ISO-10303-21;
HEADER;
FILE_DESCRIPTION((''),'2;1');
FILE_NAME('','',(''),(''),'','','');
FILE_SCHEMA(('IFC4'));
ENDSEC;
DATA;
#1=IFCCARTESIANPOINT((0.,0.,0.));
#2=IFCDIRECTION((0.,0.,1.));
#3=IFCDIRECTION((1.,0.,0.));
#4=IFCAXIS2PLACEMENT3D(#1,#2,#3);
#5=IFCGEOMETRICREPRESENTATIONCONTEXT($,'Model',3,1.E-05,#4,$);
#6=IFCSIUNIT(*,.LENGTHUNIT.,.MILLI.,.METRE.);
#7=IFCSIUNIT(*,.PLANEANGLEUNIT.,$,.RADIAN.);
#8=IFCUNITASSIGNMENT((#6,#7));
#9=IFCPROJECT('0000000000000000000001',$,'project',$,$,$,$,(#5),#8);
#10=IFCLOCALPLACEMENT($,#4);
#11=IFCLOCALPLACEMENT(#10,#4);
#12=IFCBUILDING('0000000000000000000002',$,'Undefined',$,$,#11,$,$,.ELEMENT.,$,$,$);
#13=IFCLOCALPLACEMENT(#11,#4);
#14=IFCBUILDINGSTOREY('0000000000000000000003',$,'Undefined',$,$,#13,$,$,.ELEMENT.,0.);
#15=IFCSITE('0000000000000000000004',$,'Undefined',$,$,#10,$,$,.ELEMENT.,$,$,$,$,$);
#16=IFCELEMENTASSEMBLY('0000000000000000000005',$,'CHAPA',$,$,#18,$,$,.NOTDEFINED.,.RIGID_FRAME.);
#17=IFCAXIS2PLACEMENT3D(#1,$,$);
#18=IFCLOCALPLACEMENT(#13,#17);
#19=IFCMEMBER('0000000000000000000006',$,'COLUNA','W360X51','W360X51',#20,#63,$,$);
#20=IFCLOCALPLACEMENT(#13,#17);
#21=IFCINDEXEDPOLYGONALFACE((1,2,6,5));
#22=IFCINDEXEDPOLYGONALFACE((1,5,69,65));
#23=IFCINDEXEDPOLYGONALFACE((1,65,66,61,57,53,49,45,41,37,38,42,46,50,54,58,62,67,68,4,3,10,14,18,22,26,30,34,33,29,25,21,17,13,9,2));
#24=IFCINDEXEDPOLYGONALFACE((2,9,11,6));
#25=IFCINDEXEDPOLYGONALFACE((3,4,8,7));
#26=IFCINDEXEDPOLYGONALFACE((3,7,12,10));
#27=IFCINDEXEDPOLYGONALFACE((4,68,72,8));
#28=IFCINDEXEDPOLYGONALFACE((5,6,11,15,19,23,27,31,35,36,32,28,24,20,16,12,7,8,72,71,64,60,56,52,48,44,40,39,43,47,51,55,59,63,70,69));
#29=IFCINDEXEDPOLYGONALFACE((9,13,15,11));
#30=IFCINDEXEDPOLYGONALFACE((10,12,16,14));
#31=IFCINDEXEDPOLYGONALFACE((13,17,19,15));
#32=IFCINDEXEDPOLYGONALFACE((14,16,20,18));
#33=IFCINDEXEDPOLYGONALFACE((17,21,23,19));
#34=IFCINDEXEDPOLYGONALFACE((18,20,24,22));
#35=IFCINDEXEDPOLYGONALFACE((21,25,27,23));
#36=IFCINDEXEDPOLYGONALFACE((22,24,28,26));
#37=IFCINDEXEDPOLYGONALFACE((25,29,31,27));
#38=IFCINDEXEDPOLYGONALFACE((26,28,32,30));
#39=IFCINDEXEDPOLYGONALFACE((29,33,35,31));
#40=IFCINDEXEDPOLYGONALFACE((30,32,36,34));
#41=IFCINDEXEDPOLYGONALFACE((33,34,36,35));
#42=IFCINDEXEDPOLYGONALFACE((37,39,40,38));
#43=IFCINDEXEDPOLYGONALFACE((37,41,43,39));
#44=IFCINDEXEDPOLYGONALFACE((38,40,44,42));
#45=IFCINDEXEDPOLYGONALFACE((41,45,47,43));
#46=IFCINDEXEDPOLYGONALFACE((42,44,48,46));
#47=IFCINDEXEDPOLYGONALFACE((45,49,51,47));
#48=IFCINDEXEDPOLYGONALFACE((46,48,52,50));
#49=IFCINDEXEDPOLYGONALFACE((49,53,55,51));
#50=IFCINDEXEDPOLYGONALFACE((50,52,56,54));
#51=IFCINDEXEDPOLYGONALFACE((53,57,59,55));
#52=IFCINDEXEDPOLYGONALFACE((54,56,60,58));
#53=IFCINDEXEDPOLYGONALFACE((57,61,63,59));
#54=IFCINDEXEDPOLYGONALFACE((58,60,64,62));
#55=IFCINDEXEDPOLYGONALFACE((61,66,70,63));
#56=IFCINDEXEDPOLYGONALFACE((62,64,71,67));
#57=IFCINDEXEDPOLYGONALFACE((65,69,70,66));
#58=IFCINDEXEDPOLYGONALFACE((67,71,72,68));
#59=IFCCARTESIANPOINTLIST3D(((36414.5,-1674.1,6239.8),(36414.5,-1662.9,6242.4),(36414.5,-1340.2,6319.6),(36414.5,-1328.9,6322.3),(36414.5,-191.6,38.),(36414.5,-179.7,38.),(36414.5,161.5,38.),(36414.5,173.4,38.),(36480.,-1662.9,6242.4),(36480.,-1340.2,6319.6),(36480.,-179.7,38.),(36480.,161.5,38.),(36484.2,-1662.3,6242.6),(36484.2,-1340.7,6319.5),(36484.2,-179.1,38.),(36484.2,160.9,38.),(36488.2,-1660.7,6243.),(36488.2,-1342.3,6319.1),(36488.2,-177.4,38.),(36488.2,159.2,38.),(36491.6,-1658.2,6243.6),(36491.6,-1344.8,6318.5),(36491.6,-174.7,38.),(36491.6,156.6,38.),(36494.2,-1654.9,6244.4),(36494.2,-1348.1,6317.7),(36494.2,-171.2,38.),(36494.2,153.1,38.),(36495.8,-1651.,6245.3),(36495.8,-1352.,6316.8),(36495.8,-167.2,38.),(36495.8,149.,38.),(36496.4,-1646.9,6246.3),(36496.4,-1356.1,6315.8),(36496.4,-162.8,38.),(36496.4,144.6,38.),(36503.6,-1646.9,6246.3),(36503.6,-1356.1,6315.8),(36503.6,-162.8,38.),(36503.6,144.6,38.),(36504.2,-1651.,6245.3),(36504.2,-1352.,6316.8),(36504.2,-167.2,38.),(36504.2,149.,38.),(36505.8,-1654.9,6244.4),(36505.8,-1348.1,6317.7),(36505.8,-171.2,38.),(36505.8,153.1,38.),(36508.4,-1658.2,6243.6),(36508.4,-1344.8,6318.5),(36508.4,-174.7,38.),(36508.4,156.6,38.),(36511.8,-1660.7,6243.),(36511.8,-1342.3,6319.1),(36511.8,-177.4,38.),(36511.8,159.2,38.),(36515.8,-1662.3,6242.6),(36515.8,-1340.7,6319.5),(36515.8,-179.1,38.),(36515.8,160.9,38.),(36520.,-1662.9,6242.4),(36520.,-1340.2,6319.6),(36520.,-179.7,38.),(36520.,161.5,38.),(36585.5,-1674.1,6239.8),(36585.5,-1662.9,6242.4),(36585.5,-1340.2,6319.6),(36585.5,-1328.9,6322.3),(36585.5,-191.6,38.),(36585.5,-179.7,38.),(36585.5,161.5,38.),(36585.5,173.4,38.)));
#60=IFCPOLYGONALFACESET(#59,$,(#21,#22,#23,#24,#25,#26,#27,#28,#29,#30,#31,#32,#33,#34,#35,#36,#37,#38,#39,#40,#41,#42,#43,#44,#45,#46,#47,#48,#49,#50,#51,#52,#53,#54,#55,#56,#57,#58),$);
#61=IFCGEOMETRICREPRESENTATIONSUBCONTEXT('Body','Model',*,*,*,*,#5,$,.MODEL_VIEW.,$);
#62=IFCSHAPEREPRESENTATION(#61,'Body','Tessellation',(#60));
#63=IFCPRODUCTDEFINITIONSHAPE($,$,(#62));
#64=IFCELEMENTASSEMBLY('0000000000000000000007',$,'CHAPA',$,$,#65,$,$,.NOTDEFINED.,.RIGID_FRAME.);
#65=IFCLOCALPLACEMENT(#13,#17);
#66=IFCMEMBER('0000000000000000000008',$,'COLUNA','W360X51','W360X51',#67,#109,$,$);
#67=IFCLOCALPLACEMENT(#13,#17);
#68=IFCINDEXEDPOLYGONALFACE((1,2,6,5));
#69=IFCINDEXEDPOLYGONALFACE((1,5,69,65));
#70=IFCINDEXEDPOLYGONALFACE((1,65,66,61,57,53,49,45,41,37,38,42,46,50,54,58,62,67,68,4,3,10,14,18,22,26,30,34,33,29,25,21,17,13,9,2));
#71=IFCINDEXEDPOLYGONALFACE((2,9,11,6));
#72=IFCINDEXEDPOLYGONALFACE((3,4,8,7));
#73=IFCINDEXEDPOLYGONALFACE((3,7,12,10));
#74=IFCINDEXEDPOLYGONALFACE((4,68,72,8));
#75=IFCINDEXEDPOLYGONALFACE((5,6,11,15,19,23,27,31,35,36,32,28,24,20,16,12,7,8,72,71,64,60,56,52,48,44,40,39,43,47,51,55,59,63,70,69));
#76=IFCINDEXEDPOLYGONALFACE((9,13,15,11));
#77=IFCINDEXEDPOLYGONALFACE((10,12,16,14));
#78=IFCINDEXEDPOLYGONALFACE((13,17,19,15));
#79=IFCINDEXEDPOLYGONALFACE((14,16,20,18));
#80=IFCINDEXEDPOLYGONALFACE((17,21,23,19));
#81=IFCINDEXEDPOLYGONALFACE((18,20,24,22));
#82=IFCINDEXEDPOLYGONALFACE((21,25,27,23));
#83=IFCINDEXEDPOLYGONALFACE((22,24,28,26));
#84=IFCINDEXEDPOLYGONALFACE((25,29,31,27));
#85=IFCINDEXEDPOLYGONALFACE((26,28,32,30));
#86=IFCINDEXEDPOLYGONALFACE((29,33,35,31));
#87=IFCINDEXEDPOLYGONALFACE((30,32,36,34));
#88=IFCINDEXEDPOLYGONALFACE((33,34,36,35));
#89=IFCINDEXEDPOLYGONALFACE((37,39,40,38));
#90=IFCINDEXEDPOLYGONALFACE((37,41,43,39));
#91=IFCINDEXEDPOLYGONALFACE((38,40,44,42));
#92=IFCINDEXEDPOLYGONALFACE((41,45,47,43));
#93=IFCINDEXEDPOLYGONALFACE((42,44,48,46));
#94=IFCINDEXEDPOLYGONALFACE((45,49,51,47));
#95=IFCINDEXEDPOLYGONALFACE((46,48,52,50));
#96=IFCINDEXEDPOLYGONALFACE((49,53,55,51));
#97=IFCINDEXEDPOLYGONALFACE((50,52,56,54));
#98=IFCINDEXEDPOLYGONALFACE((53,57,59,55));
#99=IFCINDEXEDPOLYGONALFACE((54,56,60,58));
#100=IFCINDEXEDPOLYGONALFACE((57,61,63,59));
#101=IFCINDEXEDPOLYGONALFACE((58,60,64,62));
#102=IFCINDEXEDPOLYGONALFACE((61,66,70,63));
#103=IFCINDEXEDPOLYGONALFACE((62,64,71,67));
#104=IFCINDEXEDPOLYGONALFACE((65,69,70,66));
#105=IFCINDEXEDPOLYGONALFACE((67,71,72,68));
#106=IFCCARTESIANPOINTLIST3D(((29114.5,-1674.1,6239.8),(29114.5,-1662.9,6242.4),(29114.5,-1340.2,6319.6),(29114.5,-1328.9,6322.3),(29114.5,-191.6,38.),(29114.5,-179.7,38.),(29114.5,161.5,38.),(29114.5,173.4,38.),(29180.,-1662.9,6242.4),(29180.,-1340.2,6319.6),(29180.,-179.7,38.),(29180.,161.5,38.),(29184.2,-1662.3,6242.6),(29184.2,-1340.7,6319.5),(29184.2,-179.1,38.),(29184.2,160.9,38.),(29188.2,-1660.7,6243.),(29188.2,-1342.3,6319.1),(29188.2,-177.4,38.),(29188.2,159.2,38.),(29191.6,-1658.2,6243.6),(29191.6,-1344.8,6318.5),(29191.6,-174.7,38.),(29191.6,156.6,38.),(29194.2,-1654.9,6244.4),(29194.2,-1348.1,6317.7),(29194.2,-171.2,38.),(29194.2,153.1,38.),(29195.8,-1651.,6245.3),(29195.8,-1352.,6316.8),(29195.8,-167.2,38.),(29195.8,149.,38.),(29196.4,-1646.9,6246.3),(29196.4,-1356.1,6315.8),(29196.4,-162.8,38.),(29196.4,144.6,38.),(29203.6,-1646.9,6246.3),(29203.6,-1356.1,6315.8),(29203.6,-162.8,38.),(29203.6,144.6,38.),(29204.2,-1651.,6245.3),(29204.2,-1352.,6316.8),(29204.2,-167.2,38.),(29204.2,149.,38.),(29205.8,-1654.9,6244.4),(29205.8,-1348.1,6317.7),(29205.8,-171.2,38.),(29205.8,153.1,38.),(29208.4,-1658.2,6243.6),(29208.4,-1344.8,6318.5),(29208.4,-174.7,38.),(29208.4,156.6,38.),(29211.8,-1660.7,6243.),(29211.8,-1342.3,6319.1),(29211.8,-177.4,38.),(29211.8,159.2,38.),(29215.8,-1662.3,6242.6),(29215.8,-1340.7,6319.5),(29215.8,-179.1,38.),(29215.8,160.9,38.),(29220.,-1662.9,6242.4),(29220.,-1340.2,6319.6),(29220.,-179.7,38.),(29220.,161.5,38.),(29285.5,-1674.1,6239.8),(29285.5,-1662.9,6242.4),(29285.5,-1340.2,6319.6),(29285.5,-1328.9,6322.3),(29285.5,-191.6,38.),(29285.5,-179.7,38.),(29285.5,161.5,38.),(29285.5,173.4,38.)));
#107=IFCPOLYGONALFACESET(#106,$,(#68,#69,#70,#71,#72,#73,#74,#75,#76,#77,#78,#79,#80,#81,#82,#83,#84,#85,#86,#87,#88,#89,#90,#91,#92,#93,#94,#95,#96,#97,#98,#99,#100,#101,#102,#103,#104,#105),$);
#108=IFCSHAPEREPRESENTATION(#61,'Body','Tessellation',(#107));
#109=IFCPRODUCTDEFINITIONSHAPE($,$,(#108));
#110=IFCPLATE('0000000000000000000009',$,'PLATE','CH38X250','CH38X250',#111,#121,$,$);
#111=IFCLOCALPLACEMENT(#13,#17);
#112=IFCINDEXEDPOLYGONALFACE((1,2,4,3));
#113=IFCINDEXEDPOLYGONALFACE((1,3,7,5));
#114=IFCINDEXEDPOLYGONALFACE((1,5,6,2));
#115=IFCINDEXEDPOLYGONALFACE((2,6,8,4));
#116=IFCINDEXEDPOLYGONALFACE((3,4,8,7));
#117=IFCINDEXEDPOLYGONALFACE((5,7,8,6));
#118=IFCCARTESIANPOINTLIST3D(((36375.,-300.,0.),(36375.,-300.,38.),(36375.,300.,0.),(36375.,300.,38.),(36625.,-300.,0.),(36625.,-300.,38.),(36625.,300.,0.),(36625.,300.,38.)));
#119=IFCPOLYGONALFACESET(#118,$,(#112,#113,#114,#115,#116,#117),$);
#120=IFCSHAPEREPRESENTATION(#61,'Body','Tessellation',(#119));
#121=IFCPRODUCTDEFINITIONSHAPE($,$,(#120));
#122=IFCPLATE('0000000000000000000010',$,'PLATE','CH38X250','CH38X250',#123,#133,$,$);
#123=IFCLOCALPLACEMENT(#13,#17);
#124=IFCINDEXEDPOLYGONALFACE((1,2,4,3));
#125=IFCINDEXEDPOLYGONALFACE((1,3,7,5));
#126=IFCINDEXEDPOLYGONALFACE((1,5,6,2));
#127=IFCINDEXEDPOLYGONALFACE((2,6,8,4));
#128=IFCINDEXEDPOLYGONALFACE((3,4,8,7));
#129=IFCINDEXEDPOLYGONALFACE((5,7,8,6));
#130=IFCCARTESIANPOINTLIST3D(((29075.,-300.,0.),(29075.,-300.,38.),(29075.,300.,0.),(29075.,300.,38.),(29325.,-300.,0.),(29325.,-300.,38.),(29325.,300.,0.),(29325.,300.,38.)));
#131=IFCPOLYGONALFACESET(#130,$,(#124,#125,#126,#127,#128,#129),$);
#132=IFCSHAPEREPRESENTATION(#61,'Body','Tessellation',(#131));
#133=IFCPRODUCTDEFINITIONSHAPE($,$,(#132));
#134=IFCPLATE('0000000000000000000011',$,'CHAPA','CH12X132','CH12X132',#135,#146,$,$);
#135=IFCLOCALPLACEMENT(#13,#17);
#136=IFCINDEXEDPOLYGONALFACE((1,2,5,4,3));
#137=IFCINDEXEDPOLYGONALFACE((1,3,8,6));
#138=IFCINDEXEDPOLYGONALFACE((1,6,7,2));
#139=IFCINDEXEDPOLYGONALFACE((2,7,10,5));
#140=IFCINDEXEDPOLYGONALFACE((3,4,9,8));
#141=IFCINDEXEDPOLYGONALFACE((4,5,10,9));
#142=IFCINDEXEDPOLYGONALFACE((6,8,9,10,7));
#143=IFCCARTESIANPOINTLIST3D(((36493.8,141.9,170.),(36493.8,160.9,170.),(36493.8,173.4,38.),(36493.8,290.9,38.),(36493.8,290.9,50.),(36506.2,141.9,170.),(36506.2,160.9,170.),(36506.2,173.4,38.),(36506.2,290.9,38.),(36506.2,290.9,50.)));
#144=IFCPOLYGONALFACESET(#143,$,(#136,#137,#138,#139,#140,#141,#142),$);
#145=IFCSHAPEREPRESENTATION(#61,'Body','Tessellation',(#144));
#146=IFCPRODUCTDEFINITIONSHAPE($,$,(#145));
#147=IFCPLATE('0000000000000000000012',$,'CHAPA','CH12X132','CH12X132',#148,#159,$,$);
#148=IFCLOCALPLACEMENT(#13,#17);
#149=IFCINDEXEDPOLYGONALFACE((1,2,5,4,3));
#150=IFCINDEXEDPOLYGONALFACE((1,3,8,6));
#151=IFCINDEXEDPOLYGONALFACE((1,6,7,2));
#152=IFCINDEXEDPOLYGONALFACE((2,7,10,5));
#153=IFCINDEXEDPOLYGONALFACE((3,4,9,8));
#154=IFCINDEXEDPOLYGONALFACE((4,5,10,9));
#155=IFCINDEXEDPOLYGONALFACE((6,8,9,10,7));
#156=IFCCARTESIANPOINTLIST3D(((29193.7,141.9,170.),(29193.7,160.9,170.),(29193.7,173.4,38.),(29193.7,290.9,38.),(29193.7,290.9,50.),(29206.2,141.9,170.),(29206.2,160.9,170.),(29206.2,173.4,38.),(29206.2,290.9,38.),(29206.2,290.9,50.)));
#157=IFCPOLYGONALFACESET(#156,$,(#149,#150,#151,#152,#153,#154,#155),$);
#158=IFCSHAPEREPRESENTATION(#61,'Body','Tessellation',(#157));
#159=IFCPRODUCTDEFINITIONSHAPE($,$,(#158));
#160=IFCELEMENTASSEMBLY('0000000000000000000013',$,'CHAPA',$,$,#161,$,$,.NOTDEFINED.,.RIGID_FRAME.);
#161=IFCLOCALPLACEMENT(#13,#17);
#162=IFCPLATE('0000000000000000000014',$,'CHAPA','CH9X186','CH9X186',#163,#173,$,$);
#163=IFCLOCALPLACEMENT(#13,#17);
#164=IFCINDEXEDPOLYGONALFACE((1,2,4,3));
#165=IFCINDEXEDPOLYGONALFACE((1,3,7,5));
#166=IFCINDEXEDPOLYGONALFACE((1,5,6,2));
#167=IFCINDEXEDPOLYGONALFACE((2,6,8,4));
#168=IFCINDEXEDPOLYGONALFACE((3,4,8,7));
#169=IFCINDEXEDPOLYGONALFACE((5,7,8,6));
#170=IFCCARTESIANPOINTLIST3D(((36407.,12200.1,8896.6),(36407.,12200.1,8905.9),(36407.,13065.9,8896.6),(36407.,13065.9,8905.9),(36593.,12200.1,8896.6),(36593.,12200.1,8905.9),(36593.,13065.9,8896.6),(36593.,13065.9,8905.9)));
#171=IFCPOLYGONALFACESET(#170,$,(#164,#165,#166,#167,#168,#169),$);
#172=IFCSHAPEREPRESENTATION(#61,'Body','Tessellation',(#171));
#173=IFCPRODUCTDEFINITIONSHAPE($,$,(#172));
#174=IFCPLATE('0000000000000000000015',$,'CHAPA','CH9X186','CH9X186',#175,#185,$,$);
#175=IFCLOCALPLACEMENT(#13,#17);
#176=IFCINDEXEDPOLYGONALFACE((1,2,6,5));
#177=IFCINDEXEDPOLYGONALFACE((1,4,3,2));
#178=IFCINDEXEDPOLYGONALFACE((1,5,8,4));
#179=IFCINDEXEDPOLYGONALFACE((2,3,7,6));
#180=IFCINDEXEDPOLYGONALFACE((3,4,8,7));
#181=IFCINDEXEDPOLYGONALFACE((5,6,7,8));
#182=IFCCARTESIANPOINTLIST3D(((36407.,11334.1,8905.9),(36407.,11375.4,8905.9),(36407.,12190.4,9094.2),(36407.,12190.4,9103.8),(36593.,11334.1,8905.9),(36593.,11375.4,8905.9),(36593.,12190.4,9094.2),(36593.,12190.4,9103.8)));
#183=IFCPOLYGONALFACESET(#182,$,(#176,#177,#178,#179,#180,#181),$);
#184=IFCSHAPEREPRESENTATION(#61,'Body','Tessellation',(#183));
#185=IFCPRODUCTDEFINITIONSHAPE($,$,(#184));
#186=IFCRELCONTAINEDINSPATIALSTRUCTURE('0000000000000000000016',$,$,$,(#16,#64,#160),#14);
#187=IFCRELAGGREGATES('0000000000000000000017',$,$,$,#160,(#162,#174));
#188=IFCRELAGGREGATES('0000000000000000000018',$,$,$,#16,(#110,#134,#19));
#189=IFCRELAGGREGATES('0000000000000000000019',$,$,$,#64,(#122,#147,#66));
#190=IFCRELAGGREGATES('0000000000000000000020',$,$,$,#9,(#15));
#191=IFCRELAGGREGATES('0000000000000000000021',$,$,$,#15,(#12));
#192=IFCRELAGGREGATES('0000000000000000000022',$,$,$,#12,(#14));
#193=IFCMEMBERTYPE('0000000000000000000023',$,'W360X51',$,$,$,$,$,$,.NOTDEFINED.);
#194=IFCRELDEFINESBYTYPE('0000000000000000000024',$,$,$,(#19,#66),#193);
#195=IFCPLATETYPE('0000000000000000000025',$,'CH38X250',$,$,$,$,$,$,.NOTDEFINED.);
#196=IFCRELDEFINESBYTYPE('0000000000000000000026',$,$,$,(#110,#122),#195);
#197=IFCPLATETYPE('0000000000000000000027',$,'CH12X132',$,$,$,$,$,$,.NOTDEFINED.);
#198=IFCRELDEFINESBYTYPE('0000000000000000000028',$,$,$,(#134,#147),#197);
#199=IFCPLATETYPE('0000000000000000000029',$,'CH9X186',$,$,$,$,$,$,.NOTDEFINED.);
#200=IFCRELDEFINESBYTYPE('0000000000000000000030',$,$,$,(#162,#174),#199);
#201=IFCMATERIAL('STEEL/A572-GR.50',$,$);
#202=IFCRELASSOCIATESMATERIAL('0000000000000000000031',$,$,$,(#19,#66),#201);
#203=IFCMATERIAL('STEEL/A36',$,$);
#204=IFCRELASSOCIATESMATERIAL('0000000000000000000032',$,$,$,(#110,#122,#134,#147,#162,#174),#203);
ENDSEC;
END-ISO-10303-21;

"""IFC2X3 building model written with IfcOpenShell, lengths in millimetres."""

from ifc_helpers import new_model, si_unit, frame, origin_with_axes, origin_2d_with_axis, place, context, subcontext, project, spatial, polyline, i_section, outline, extrude, clip, halfspace, material, type_object, element, aggregate, save


model = new_model("IFC2X3")

# Units and contexts
model_context = context("Model", 3, precision=1e-05, world=origin_with_axes())
body_context = subcontext(model_context, "Body", "Model", "MODEL_VIEW")
ifc_project = project(units=[si_unit("LENGTHUNIT", "METRE", prefix="MILLI"), si_unit("PLANEANGLEUNIT", "RADIAN")], contexts=[model_context])

# Site, building, storey
site_placement = place(None, origin_with_axes())
site = spatial("IfcSite", under=ifc_project, at=site_placement, Name="Undefined", CompositionType="ELEMENT")
building_placement = place(site_placement, origin_with_axes())
building = spatial("IfcBuilding", under=site, at=building_placement, Name="Undefined", CompositionType="ELEMENT")
storey_placement = place(building_placement, origin_with_axes())
storey = spatial("IfcBuildingStorey", under=building, at=storey_placement, Name="Undefined", CompositionType="ELEMENT", Elevation=0.0)

# Element assemblies, members
assembly_1_placement = place(storey_placement, origin_with_axes())
assembly_1 = element("IfcElementAssembly", 1, at=assembly_1_placement, inside=storey, Name="CHAPA", AssemblyPlace="NOTDEFINED", PredefinedType="RIGID_FRAME")
ifc_material_1 = material(Name="STEEL/A572-GR.50")
member_type = type_object("IfcMemberType", Name="W360X51", PredefinedType="NOTDEFINED")
member_1_placement = place(assembly_1_placement, frame((36500.0, 23.3, -97.3), z_axis=(0.0, -0.972595, -0.232504), x_axis=(0.0, -0.232504, 0.972595)))
member_1 = element("IfcMember", 2, at=member_1_placement, type_object=member_type, material=ifc_material_1, Name="COLUNA", Description="W360X51", ObjectType="W360X51", context=body_context, shape_type="Clipping", body=[
    clip(clip(extrude(i_section(OverallWidth=171.0, OverallDepth=355.0, WebThickness=7.2, FlangeThickness=11.6, FilletRadius=16.4, at=origin_2d_with_axis()), frame((6558.0, 0.0, 0.0), z_axis=(-1.0, 0.0, 0.0), x_axis=(0.0, -1.0, 0.0)), (0.0, 0.0, 1.0), 6542.9), halfspace(frame((94.5, 85.5, -186.3), z_axis=(-0.972595, 0.0, 0.232504), x_axis=(0.232504, 0.0, 0.972595)), False)), halfspace(frame((96.6, 0.0, -177.5), z_axis=(0.972595, 0.0, -0.232504), x_axis=(0.0, -1.0, 0.0)), True)),
])
assembly_2_placement = place(storey_placement, origin_with_axes())
assembly_2 = element("IfcElementAssembly", 3, at=assembly_2_placement, inside=storey, Name="CHAPA", AssemblyPlace="NOTDEFINED", PredefinedType="RIGID_FRAME")
member_2_placement = place(assembly_2_placement, frame((29200.0, 23.3, -97.3), z_axis=(0.0, -0.972595, -0.232504), x_axis=(0.0, -0.232504, 0.972595)))
member_2 = element("IfcMember", 4, at=member_2_placement, type_object=member_type, material=ifc_material_1, Name="COLUNA", Description="W360X51", ObjectType="W360X51", context=body_context, shape_type="Clipping", body=[
    clip(clip(extrude(i_section(OverallWidth=171.0, OverallDepth=355.0, WebThickness=7.2, FlangeThickness=11.6, FilletRadius=16.4, at=origin_2d_with_axis()), frame((6558.0, 0.0, 0.0), z_axis=(-1.0, 0.0, 0.0), x_axis=(0.0, -1.0, 0.0)), (0.0, 0.0, 1.0), 6542.9), halfspace(frame((94.5, 85.5, -186.3), z_axis=(-0.972595, 0.0, 0.232504), x_axis=(0.232504, 0.0, 0.972595)), False)), halfspace(frame((96.6, 0.0, -177.5), z_axis=(0.972595, 0.0, -0.232504), x_axis=(0.0, -1.0, 0.0)), True)),
])

# Plates
ifc_material_2 = material(Name="STEEL/A36")
plate_type_1 = type_object("IfcPlateType", Name="CH38X250", PredefinedType="NOTDEFINED")
plate_1_placement = place(assembly_1_placement, frame((36625.0, -300.0, 19.0), z_axis=(0.0, 0.0, 1.0), x_axis=(0.0, 1.0, 0.0)))
plate_1 = element("IfcPlate", 5, at=plate_1_placement, type_object=plate_type_1, material=ifc_material_2, Name="PLATE", Description="CH38X250", ObjectType="CH38X250", context=body_context, shape_type="SweptSolid", body=[
    extrude(outline(polyline([(0.0, 0.0), (600.0, 0.0), (600.0, 250.0), (0.0, 250.0), (0.0, 0.0)])), frame((0.0, 0.0, -19.0), z_axis=(0.0, 0.0, 1.0), x_axis=(1.0, 0.0, 0.0)), (0.0, 0.0, 1.0), 38.0),
])
plate_2_placement = place(assembly_2_placement, frame((29325.0, -300.0, 19.0), z_axis=(0.0, 0.0, 1.0), x_axis=(0.0, 1.0, 0.0)))
plate_2 = element("IfcPlate", 6, at=plate_2_placement, type_object=plate_type_1, material=ifc_material_2, Name="PLATE", Description="CH38X250", ObjectType="CH38X250", context=body_context, shape_type="SweptSolid", body=[
    extrude(outline(polyline([(0.0, 0.0), (600.0, 0.0), (600.0, 250.0), (0.0, 250.0), (0.0, 0.0)])), frame((0.0, 0.0, -19.0), z_axis=(0.0, 0.0, 1.0), x_axis=(1.0, 0.0, 0.0)), (0.0, 0.0, 1.0), 38.0),
])
plate_type_2 = type_object("IfcPlateType", Name="CH12X132", PredefinedType="NOTDEFINED")
plate_3_placement = place(assembly_1_placement, frame((36500.0, 173.4, 38.0), z_axis=(1.0, 0.0, 0.0), x_axis=(0.0, 1.0, 0.0)))
plate_3 = element("IfcPlate", 7, at=plate_3_placement, type_object=plate_type_2, material=ifc_material_2, Name="CHAPA", Description="CH12X132", ObjectType="CH12X132", context=body_context, shape_type="SweptSolid", body=[
    extrude(outline(polyline([(0.0, 0.0), (117.5, 0.0), (117.5, 12.0), (-12.5, 132.0), (-31.6, 132.0), (0.0, 0.0)])), frame((0.0, 0.0, -6.2), z_axis=(0.0, 0.0, 1.0), x_axis=(1.0, 0.0, 0.0)), (0.0, 0.0, 1.0), 12.5),
])
plate_4_placement = place(assembly_2_placement, frame((29200.0, 173.4, 38.0), z_axis=(1.0, 0.0, 0.0), x_axis=(0.0, 1.0, 0.0)))
plate_4 = element("IfcPlate", 8, at=plate_4_placement, type_object=plate_type_2, material=ifc_material_2, Name="CHAPA", Description="CH12X132", ObjectType="CH12X132", context=body_context, shape_type="SweptSolid", body=[
    extrude(outline(polyline([(0.0, 0.0), (117.5, 0.0), (117.5, 12.0), (-12.5, 132.0), (-31.6, 132.0), (0.0, 0.0)])), frame((0.0, 0.0, -6.2), z_axis=(0.0, 0.0, 1.0), x_axis=(1.0, 0.0, 0.0)), (0.0, 0.0, 1.0), 12.5),
])

# Element assembly, plates
assembly_3_placement = place(storey_placement, origin_with_axes())
assembly_3 = element("IfcElementAssembly", 9, at=assembly_3_placement, inside=storey, Name="CHAPA", AssemblyPlace="NOTDEFINED", PredefinedType="RIGID_FRAME")
plate_type_3 = type_object("IfcPlateType", Name="CH9X186", PredefinedType="NOTDEFINED")
plate_5_placement = place(assembly_3_placement, frame((36593.0, 12200.1, 8901.3), z_axis=(0.0, 0.0, -1.0), x_axis=(-1.0, 0.0, 0.0)))
plate_5 = element("IfcPlate", 10, at=plate_5_placement, type_object=plate_type_3, material=ifc_material_2, Name="CHAPA", Description="CH9X186", ObjectType="CH9X186", context=body_context, shape_type="SweptSolid", body=[
    extrude(outline(polyline([(0.0, 0.0), (186.0, 0.0), (186.0, 865.8), (0.0, 865.8), (0.0, 0.0)])), frame((0.0, 0.0, -4.7), z_axis=(0.0, 0.0, 1.0), x_axis=(1.0, 0.0, 0.0)), (0.0, 0.0, 1.0), 9.3),
])
plate_6_placement = place(assembly_3_placement, frame((36593.0, 12191.4, 9099.3), z_axis=(0.0, -0.225125, 0.97433), x_axis=(-1.0, 0.0, 0.0)))
plate_6 = element("IfcPlate", 11, at=plate_6_placement, type_object=plate_type_3, material=ifc_material_2, Name="CHAPA", Description="CH9X186", ObjectType="CH9X186", context=body_context, shape_type="Clipping", body=[
    clip(clip(extrude(outline(polyline([(0.0, 0.0), (186.0, 0.0), (186.0, 878.9), (0.0, 878.9), (0.0, 0.0)])), frame((0.0, 0.0, -4.7), z_axis=(0.0, 0.0, 1.0), x_axis=(1.0, 0.0, 0.0)), (0.0, 0.0, 1.0), 9.3), halfspace(frame((186.0, -500.0, -314.0), z_axis=(0.0, 0.225128, -0.974329), x_axis=(0.0, 0.974329, 0.225128)), False)), halfspace(frame((0.0, 2.1, -4.6), z_axis=(0.0, -0.97433, -0.225125), x_axis=(0.0, -0.225125, 0.97433)), False)),
])

aggregate(assembly_3, [plate_5, plate_6])

aggregate(assembly_1, [plate_1, plate_3, member_1])
aggregate(assembly_2, [plate_2, plate_4, member_2])

save(model, "model.ifc")
